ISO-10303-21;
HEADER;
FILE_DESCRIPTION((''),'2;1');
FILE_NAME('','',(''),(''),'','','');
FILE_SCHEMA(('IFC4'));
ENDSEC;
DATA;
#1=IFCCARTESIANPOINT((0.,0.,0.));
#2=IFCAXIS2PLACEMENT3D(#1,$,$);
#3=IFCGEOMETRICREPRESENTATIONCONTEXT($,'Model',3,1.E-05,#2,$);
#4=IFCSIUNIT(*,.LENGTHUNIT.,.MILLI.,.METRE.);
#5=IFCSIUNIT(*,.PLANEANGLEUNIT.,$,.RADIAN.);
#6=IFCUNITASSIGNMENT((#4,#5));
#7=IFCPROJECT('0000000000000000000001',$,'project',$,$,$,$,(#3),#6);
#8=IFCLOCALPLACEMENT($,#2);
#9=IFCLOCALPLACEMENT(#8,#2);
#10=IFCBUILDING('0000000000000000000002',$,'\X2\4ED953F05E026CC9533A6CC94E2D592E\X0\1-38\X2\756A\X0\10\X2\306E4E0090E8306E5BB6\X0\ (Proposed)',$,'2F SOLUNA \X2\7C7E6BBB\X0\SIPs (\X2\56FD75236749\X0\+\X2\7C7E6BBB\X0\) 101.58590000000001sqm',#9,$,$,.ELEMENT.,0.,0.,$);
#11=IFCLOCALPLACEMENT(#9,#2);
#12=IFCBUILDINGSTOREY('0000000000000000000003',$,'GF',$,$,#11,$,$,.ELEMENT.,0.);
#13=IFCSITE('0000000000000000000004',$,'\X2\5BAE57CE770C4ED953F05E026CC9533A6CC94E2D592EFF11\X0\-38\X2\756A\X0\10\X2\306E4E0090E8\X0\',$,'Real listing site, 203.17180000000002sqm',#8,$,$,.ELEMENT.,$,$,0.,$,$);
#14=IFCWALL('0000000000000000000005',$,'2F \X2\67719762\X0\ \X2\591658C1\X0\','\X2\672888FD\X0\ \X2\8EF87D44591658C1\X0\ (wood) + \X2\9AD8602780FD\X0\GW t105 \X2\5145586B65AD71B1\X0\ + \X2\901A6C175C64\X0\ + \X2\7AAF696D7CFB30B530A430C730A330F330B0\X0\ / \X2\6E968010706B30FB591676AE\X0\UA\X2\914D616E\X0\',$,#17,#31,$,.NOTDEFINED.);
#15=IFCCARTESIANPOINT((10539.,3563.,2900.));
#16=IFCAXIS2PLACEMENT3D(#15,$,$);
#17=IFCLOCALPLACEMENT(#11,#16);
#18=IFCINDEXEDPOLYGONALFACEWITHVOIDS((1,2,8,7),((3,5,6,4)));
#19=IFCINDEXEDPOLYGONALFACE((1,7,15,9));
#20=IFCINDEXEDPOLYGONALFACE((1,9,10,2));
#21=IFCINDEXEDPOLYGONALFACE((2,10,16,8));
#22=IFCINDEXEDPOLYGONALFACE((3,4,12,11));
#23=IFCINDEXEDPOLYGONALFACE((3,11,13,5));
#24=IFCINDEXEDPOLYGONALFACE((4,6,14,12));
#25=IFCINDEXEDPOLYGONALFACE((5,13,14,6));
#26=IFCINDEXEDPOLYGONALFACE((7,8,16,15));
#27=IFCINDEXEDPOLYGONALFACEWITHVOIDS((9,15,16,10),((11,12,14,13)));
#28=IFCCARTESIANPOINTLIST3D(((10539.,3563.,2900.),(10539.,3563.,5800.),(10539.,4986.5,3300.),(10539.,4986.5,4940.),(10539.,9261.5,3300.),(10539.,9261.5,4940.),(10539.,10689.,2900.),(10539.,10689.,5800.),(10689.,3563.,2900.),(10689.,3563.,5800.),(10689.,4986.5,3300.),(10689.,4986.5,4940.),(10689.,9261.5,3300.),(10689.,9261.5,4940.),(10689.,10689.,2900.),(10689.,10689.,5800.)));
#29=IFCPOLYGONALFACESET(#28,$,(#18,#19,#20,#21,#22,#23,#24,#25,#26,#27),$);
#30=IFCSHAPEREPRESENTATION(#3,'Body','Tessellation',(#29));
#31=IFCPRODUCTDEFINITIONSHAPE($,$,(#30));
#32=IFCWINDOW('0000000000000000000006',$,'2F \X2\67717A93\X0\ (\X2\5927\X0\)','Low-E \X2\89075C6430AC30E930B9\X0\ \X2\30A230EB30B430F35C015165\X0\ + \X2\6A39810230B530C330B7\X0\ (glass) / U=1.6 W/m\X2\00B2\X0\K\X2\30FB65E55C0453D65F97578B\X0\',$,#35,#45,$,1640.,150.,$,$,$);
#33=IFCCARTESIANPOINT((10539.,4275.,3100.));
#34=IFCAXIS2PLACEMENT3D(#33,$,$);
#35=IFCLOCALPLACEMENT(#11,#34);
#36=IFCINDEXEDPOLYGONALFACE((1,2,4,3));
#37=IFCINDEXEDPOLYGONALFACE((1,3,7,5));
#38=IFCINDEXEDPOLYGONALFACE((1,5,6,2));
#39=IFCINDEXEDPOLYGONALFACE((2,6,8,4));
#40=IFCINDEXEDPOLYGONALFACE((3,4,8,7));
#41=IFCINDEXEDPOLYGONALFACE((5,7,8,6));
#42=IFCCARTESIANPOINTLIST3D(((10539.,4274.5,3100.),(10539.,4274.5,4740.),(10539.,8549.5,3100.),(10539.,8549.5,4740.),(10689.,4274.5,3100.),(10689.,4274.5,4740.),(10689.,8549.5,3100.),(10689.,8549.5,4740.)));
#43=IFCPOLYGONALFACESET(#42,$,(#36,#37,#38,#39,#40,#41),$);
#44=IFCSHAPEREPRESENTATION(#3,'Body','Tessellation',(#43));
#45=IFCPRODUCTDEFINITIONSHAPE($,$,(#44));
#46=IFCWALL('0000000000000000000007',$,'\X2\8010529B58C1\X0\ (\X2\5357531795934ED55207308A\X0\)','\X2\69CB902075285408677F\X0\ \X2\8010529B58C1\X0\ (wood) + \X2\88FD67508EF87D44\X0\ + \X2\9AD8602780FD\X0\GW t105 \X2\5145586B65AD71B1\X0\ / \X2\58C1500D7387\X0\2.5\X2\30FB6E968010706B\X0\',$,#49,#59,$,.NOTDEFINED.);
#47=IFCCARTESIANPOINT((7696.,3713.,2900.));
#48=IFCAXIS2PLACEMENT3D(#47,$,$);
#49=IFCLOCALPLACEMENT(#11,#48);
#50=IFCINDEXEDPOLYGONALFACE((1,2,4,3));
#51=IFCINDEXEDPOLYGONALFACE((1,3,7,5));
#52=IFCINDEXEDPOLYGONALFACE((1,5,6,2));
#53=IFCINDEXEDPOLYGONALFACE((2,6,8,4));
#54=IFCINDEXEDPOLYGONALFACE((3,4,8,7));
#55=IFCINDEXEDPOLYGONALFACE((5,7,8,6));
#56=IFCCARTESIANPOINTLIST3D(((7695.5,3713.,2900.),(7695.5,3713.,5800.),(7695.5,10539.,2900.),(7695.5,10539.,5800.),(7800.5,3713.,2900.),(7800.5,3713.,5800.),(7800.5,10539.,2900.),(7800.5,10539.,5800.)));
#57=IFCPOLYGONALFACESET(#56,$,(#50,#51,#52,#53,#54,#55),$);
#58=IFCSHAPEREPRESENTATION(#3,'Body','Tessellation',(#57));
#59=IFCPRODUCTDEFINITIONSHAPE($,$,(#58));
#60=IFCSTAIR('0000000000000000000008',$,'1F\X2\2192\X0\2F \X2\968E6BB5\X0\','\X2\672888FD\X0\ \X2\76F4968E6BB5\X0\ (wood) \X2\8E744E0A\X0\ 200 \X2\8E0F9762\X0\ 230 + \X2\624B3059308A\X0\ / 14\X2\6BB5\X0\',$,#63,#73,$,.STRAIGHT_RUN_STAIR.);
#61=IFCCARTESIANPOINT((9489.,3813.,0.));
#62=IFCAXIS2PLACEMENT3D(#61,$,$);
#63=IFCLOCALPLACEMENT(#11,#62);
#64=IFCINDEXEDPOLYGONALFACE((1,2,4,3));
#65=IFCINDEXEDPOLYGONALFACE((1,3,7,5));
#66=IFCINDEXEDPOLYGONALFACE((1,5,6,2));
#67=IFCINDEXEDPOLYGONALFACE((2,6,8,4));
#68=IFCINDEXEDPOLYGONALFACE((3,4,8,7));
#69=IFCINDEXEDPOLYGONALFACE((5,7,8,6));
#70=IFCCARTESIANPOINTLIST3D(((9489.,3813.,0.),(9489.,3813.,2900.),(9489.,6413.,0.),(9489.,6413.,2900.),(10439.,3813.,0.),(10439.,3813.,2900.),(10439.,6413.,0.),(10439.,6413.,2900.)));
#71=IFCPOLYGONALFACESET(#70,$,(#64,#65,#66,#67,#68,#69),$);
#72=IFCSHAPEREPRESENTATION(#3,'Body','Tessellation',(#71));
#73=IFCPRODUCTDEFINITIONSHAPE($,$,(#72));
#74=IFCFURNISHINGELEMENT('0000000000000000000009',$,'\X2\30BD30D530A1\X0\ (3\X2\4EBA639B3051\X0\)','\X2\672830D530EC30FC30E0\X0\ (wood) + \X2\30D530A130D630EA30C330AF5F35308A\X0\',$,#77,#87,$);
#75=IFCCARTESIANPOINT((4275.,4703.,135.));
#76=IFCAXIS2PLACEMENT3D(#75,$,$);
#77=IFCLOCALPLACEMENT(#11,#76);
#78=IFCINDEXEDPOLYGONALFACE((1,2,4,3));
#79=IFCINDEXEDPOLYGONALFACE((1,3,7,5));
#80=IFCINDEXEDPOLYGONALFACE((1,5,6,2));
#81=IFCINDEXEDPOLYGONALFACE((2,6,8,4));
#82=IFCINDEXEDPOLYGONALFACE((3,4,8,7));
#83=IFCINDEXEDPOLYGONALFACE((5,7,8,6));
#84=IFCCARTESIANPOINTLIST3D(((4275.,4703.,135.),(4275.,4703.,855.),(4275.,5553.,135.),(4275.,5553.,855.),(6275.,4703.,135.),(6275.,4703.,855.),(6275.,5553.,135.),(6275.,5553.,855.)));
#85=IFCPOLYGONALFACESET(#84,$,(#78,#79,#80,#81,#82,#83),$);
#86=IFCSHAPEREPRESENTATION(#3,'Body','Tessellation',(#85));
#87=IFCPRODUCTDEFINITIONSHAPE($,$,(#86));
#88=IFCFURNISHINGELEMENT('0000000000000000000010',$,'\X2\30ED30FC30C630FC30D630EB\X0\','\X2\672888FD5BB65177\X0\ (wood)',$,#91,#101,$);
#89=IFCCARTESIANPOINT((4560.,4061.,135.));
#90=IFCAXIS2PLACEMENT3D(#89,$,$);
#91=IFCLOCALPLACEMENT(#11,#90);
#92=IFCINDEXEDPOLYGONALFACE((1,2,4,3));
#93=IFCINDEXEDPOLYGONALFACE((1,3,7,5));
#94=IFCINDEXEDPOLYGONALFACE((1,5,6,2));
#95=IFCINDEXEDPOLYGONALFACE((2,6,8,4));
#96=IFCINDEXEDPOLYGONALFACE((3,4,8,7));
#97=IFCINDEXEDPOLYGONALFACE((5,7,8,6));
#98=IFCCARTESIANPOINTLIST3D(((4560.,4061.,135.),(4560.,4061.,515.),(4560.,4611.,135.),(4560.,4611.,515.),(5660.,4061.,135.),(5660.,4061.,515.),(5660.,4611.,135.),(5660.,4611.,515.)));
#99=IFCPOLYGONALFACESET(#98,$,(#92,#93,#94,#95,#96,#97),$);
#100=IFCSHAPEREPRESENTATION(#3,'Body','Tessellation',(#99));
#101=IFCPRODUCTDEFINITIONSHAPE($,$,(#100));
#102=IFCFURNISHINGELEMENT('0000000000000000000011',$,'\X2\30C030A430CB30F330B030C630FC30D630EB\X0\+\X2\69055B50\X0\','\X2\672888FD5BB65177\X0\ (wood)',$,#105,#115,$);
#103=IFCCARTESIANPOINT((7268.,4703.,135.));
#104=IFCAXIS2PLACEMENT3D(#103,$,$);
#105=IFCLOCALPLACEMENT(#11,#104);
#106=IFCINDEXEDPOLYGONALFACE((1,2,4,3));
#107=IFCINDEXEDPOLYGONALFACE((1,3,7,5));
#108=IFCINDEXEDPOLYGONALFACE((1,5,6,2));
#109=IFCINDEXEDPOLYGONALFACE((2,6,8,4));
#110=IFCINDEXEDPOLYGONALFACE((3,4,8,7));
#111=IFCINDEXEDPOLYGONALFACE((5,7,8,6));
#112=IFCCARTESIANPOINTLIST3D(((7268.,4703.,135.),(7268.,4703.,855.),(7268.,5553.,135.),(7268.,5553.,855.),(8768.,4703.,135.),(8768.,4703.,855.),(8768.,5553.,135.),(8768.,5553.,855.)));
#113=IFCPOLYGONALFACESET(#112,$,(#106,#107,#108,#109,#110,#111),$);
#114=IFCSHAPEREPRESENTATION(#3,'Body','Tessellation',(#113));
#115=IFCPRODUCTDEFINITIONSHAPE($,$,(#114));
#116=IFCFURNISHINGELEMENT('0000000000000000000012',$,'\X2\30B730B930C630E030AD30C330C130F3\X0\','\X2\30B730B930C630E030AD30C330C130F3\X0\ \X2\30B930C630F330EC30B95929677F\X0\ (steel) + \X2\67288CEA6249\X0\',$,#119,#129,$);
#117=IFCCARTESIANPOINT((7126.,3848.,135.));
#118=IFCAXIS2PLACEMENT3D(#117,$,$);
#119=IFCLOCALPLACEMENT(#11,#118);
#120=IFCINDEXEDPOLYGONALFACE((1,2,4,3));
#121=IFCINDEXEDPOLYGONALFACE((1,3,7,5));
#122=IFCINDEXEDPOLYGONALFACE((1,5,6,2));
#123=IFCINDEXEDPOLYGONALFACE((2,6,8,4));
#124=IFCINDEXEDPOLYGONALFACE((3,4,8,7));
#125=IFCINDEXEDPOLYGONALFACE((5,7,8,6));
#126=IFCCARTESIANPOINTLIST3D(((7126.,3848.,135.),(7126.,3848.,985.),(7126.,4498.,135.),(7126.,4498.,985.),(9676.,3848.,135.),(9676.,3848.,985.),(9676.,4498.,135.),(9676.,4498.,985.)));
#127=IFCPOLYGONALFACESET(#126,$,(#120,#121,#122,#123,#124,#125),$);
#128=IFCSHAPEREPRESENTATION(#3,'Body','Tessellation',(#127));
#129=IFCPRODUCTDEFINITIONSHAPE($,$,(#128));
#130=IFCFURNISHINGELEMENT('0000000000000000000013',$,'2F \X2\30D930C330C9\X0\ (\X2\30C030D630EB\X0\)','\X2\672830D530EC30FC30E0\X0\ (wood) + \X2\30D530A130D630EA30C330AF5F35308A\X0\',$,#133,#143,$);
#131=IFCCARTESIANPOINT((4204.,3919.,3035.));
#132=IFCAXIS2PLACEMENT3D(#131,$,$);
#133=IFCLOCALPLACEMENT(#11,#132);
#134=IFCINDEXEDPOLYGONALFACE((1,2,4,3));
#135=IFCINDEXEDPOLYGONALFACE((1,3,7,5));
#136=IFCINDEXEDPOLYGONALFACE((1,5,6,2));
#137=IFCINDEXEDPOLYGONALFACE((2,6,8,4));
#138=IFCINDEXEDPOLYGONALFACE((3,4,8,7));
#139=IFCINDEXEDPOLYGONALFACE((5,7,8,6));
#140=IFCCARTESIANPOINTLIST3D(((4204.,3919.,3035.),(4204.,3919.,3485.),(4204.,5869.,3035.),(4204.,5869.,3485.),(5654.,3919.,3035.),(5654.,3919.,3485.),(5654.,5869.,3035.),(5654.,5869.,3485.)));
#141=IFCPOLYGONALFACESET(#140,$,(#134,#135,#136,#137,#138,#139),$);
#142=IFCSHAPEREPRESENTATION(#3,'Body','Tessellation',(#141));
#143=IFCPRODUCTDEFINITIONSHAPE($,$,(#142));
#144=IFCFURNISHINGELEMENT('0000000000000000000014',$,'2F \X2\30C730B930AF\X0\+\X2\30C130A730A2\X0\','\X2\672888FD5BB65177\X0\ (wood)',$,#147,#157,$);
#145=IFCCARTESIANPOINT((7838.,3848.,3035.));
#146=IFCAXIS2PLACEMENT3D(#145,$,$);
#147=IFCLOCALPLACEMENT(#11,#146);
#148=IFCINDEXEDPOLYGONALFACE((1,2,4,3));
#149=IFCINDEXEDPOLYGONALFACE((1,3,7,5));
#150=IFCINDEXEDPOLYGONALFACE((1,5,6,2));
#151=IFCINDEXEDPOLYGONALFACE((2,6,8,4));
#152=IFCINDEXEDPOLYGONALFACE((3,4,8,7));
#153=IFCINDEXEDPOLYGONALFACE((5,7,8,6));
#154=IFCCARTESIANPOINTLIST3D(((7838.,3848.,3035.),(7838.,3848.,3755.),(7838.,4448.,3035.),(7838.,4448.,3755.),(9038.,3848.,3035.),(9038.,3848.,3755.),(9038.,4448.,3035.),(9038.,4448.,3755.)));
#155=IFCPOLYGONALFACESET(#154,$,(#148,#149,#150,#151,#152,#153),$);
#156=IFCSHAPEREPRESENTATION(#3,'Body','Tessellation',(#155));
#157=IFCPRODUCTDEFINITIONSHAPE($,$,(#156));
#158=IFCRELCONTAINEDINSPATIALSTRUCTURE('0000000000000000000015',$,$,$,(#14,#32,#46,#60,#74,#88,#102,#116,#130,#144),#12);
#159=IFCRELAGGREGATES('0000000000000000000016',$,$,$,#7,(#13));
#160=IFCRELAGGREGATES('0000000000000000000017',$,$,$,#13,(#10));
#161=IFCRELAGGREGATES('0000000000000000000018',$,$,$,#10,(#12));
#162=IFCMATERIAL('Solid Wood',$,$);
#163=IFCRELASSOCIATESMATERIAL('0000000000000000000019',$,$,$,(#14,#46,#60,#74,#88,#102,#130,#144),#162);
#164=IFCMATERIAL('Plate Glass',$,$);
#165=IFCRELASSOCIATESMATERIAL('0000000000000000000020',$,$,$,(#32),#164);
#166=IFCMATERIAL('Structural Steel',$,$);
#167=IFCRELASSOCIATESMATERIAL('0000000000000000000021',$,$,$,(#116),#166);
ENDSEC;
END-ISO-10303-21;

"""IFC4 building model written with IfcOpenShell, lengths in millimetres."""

from ifc_helpers import new_model, si_unit, frame, frame_2d, origin, place, context, project, spatial, rectangle, extrude, material, element, fill, save


model = new_model("IFC4")

# Units and contexts
model_context = context("Model", 3, precision=1e-05, world=origin())
ifc_project = project(units=[si_unit("LENGTHUNIT", "METRE", prefix="MILLI"), si_unit("PLANEANGLEUNIT", "RADIAN")], contexts=[model_context])

# Site, building, storey
site_placement = place(None, origin())
site = spatial("IfcSite", under=ifc_project, at=site_placement, Name="宮城県仙台市泉区泉中央１-38番10の一部", ObjectType="Real listing site, 203.17180000000002sqm", CompositionType="ELEMENT", RefElevation=0.0)
building_placement = place(site_placement, origin())
building = spatial("IfcBuilding", under=site, at=building_placement, Name="仙台市泉区泉中央1-38番10の一部の家 (Proposed)", ObjectType="2F SOLUNA 籾殻SIPs (国産杉+籾殻) 101.58590000000001sqm", CompositionType="ELEMENT", ElevationOfRefHeight=0.0, ElevationOfTerrain=0.0)
storey_placement = place(building_placement, origin())
storey = spatial("IfcBuildingStorey", under=building, at=storey_placement, Name="GF", CompositionType="ELEMENT", Elevation=0.0)

# Shared definitions
ifc_material_1 = material(Name="Solid Wood")
ifc_material_2 = material(Name="Plate Glass")

# Wall, opening, window
wall_1_placement = place(storey_placement, frame((10539.0, 3563.0, 2900.0)))
wall_1 = element("IfcWall", 1, at=wall_1_placement, inside=storey, material=ifc_material_1, Name="2F 東面 外壁", Description="木製 軸組外壁 (wood) + 高性能GW t105 充填断熱 + 通気層 + 窯業系サイディング / 準耐火・外皮UA配慮", PredefinedType="NOTDEFINED", context=model_context, shape_type="SweptSolid", body=[
    extrude(rectangle(XDim=150.0, YDim=7126.0, at=frame_2d((75.0, 3563.0))), frame((10539.0, 3563.0, 2900.0)), (0.0, 0.0, 1.0), 2900.0),
])
opening_1_placement = place(storey_placement, frame((10539.0, 4275.0, 3100.0)))
opening_1 = element("IfcOpeningElement", 2, at=opening_1_placement, cuts=wall_1, PredefinedType="NOTDEFINED", context=model_context, shape_type="SweptSolid", body=[
    extrude(rectangle(XDim=150.0, YDim=4275.0, at=frame_2d((75.0, 2137.0))), frame((10539.0, 4275.0, 3100.0)), (0.0, 0.0, 1.0), 1640.0),
])
window_1_placement = place(storey_placement, frame((10539.0, 4275.0, 3100.0)))
window_1 = element("IfcWindow", 3, at=window_1_placement, inside=storey, material=ifc_material_2, Name="2F 東窓 (大)", Description="Low-E 複層ガラス アルゴン封入 + 樹脂サッシ (glass) / U=1.6 W/m²K・日射取得型", OverallHeight=1640.0, OverallWidth=150.0, context=model_context, shape_type="SweptSolid", body=[
    extrude(rectangle(XDim=150.0, YDim=4275.0, at=frame_2d((75.0, 2137.0))), frame((10539.0, 4275.0, 3100.0)), (0.0, 0.0, 1.0), 1640.0),
])
fill(opening_1, window_1)

# Wall
wall_2_placement = place(storey_placement, frame((7696.0, 3713.0, 2900.0)))
element("IfcWall", 4, at=wall_2_placement, inside=storey, material=ifc_material_1, Name="耐力壁 (南北間仕切り)", Description="構造用合板 耐力壁 (wood) + 製材軸組 + 高性能GW t105 充填断熱 / 壁倍率2.5・準耐火", PredefinedType="NOTDEFINED", context=model_context, shape_type="SweptSolid", body=[
    extrude(rectangle(XDim=105.0, YDim=6826.0, at=frame_2d((52.0, 3413.0))), frame((7696.0, 3713.0, 2900.0)), (0.0, 0.0, 1.0), 2900.0),
])

# Stair
stair_placement = place(storey_placement, frame((9489.0, 3813.0, 0.0)))
element("IfcStair", 5, at=stair_placement, inside=storey, material=ifc_material_1, Name="1F→2F 階段", Description="木製 直階段 (wood) 蹴上 200 踏面 230 + 手すり / 14段", PredefinedType="STRAIGHT_RUN_STAIR", context=model_context, shape_type="SweptSolid", body=[
    extrude(rectangle(XDim=950.0, YDim=2600.0, at=frame_2d((475.0, 1300.0))), frame((9489.0, 3813.0, 0.0)), (0.0, 0.0, 1.0), 2900.0),
])

# Furnishing elements
furnishing_1_placement = place(storey_placement, frame((4275.0, 4703.0, 135.0)))
element("IfcFurnishingElement", 6, at=furnishing_1_placement, inside=storey, material=ifc_material_1, Name="ソファ (3人掛け)", Description="木フレーム (wood) + ファブリック張り", context=model_context, shape_type="SweptSolid", body=[
    extrude(rectangle(XDim=2000.0, YDim=850.0, at=frame_2d((1000.0, 425.0))), frame((4275.0, 4703.0, 135.0)), (0.0, 0.0, 1.0), 720.0),
])
furnishing_2_placement = place(storey_placement, frame((4560.0, 4061.0, 135.0)))
element("IfcFurnishingElement", 7, at=furnishing_2_placement, inside=storey, material=ifc_material_1, Name="ローテーブル", Description="木製家具 (wood)", context=model_context, shape_type="SweptSolid", body=[
    extrude(rectangle(XDim=1100.0, YDim=550.0, at=frame_2d((550.0, 275.0))), frame((4560.0, 4061.0, 135.0)), (0.0, 0.0, 1.0), 380.0),
])
furnishing_3_placement = place(storey_placement, frame((7268.0, 4703.0, 135.0)))
element("IfcFurnishingElement", 8, at=furnishing_3_placement, inside=storey, material=ifc_material_1, Name="ダイニングテーブル+椅子", Description="木製家具 (wood)", context=model_context, shape_type="SweptSolid", body=[
    extrude(rectangle(XDim=1500.0, YDim=850.0, at=frame_2d((750.0, 425.0))), frame((7268.0, 4703.0, 135.0)), (0.0, 0.0, 1.0), 720.0),
])
ifc_material_3 = material(Name="Structural Steel")
furnishing_4_placement = place(storey_placement, frame((7126.0, 3848.0, 135.0)))
element("IfcFurnishingElement", 9, at=furnishing_4_placement, inside=storey, material=ifc_material_3, Name="システムキッチン", Description="システムキッチン ステンレス天板 (steel) + 木質扉", context=model_context, shape_type="SweptSolid", body=[
    extrude(rectangle(XDim=2550.0, YDim=650.0, at=frame_2d((1275.0, 325.0))), frame((7126.0, 3848.0, 135.0)), (0.0, 0.0, 1.0), 850.0),
])
furnishing_5_placement = place(storey_placement, frame((4204.0, 3919.0, 3035.0)))
element("IfcFurnishingElement", 10, at=furnishing_5_placement, inside=storey, material=ifc_material_1, Name="2F ベッド (ダブル)", Description="木フレーム (wood) + ファブリック張り", context=model_context, shape_type="SweptSolid", body=[
    extrude(rectangle(XDim=1450.0, YDim=1950.0, at=frame_2d((725.0, 975.0))), frame((4204.0, 3919.0, 3035.0)), (0.0, 0.0, 1.0), 450.0),
])
furnishing_6_placement = place(storey_placement, frame((7838.0, 3848.0, 3035.0)))
element("IfcFurnishingElement", 11, at=furnishing_6_placement, inside=storey, material=ifc_material_1, Name="2F デスク+チェア", Description="木製家具 (wood)", context=model_context, shape_type="SweptSolid", body=[
    extrude(rectangle(XDim=1200.0, YDim=600.0, at=frame_2d((600.0, 300.0))), frame((7838.0, 3848.0, 3035.0)), (0.0, 0.0, 1.0), 720.0),
])

save(model, "model.ifc")
